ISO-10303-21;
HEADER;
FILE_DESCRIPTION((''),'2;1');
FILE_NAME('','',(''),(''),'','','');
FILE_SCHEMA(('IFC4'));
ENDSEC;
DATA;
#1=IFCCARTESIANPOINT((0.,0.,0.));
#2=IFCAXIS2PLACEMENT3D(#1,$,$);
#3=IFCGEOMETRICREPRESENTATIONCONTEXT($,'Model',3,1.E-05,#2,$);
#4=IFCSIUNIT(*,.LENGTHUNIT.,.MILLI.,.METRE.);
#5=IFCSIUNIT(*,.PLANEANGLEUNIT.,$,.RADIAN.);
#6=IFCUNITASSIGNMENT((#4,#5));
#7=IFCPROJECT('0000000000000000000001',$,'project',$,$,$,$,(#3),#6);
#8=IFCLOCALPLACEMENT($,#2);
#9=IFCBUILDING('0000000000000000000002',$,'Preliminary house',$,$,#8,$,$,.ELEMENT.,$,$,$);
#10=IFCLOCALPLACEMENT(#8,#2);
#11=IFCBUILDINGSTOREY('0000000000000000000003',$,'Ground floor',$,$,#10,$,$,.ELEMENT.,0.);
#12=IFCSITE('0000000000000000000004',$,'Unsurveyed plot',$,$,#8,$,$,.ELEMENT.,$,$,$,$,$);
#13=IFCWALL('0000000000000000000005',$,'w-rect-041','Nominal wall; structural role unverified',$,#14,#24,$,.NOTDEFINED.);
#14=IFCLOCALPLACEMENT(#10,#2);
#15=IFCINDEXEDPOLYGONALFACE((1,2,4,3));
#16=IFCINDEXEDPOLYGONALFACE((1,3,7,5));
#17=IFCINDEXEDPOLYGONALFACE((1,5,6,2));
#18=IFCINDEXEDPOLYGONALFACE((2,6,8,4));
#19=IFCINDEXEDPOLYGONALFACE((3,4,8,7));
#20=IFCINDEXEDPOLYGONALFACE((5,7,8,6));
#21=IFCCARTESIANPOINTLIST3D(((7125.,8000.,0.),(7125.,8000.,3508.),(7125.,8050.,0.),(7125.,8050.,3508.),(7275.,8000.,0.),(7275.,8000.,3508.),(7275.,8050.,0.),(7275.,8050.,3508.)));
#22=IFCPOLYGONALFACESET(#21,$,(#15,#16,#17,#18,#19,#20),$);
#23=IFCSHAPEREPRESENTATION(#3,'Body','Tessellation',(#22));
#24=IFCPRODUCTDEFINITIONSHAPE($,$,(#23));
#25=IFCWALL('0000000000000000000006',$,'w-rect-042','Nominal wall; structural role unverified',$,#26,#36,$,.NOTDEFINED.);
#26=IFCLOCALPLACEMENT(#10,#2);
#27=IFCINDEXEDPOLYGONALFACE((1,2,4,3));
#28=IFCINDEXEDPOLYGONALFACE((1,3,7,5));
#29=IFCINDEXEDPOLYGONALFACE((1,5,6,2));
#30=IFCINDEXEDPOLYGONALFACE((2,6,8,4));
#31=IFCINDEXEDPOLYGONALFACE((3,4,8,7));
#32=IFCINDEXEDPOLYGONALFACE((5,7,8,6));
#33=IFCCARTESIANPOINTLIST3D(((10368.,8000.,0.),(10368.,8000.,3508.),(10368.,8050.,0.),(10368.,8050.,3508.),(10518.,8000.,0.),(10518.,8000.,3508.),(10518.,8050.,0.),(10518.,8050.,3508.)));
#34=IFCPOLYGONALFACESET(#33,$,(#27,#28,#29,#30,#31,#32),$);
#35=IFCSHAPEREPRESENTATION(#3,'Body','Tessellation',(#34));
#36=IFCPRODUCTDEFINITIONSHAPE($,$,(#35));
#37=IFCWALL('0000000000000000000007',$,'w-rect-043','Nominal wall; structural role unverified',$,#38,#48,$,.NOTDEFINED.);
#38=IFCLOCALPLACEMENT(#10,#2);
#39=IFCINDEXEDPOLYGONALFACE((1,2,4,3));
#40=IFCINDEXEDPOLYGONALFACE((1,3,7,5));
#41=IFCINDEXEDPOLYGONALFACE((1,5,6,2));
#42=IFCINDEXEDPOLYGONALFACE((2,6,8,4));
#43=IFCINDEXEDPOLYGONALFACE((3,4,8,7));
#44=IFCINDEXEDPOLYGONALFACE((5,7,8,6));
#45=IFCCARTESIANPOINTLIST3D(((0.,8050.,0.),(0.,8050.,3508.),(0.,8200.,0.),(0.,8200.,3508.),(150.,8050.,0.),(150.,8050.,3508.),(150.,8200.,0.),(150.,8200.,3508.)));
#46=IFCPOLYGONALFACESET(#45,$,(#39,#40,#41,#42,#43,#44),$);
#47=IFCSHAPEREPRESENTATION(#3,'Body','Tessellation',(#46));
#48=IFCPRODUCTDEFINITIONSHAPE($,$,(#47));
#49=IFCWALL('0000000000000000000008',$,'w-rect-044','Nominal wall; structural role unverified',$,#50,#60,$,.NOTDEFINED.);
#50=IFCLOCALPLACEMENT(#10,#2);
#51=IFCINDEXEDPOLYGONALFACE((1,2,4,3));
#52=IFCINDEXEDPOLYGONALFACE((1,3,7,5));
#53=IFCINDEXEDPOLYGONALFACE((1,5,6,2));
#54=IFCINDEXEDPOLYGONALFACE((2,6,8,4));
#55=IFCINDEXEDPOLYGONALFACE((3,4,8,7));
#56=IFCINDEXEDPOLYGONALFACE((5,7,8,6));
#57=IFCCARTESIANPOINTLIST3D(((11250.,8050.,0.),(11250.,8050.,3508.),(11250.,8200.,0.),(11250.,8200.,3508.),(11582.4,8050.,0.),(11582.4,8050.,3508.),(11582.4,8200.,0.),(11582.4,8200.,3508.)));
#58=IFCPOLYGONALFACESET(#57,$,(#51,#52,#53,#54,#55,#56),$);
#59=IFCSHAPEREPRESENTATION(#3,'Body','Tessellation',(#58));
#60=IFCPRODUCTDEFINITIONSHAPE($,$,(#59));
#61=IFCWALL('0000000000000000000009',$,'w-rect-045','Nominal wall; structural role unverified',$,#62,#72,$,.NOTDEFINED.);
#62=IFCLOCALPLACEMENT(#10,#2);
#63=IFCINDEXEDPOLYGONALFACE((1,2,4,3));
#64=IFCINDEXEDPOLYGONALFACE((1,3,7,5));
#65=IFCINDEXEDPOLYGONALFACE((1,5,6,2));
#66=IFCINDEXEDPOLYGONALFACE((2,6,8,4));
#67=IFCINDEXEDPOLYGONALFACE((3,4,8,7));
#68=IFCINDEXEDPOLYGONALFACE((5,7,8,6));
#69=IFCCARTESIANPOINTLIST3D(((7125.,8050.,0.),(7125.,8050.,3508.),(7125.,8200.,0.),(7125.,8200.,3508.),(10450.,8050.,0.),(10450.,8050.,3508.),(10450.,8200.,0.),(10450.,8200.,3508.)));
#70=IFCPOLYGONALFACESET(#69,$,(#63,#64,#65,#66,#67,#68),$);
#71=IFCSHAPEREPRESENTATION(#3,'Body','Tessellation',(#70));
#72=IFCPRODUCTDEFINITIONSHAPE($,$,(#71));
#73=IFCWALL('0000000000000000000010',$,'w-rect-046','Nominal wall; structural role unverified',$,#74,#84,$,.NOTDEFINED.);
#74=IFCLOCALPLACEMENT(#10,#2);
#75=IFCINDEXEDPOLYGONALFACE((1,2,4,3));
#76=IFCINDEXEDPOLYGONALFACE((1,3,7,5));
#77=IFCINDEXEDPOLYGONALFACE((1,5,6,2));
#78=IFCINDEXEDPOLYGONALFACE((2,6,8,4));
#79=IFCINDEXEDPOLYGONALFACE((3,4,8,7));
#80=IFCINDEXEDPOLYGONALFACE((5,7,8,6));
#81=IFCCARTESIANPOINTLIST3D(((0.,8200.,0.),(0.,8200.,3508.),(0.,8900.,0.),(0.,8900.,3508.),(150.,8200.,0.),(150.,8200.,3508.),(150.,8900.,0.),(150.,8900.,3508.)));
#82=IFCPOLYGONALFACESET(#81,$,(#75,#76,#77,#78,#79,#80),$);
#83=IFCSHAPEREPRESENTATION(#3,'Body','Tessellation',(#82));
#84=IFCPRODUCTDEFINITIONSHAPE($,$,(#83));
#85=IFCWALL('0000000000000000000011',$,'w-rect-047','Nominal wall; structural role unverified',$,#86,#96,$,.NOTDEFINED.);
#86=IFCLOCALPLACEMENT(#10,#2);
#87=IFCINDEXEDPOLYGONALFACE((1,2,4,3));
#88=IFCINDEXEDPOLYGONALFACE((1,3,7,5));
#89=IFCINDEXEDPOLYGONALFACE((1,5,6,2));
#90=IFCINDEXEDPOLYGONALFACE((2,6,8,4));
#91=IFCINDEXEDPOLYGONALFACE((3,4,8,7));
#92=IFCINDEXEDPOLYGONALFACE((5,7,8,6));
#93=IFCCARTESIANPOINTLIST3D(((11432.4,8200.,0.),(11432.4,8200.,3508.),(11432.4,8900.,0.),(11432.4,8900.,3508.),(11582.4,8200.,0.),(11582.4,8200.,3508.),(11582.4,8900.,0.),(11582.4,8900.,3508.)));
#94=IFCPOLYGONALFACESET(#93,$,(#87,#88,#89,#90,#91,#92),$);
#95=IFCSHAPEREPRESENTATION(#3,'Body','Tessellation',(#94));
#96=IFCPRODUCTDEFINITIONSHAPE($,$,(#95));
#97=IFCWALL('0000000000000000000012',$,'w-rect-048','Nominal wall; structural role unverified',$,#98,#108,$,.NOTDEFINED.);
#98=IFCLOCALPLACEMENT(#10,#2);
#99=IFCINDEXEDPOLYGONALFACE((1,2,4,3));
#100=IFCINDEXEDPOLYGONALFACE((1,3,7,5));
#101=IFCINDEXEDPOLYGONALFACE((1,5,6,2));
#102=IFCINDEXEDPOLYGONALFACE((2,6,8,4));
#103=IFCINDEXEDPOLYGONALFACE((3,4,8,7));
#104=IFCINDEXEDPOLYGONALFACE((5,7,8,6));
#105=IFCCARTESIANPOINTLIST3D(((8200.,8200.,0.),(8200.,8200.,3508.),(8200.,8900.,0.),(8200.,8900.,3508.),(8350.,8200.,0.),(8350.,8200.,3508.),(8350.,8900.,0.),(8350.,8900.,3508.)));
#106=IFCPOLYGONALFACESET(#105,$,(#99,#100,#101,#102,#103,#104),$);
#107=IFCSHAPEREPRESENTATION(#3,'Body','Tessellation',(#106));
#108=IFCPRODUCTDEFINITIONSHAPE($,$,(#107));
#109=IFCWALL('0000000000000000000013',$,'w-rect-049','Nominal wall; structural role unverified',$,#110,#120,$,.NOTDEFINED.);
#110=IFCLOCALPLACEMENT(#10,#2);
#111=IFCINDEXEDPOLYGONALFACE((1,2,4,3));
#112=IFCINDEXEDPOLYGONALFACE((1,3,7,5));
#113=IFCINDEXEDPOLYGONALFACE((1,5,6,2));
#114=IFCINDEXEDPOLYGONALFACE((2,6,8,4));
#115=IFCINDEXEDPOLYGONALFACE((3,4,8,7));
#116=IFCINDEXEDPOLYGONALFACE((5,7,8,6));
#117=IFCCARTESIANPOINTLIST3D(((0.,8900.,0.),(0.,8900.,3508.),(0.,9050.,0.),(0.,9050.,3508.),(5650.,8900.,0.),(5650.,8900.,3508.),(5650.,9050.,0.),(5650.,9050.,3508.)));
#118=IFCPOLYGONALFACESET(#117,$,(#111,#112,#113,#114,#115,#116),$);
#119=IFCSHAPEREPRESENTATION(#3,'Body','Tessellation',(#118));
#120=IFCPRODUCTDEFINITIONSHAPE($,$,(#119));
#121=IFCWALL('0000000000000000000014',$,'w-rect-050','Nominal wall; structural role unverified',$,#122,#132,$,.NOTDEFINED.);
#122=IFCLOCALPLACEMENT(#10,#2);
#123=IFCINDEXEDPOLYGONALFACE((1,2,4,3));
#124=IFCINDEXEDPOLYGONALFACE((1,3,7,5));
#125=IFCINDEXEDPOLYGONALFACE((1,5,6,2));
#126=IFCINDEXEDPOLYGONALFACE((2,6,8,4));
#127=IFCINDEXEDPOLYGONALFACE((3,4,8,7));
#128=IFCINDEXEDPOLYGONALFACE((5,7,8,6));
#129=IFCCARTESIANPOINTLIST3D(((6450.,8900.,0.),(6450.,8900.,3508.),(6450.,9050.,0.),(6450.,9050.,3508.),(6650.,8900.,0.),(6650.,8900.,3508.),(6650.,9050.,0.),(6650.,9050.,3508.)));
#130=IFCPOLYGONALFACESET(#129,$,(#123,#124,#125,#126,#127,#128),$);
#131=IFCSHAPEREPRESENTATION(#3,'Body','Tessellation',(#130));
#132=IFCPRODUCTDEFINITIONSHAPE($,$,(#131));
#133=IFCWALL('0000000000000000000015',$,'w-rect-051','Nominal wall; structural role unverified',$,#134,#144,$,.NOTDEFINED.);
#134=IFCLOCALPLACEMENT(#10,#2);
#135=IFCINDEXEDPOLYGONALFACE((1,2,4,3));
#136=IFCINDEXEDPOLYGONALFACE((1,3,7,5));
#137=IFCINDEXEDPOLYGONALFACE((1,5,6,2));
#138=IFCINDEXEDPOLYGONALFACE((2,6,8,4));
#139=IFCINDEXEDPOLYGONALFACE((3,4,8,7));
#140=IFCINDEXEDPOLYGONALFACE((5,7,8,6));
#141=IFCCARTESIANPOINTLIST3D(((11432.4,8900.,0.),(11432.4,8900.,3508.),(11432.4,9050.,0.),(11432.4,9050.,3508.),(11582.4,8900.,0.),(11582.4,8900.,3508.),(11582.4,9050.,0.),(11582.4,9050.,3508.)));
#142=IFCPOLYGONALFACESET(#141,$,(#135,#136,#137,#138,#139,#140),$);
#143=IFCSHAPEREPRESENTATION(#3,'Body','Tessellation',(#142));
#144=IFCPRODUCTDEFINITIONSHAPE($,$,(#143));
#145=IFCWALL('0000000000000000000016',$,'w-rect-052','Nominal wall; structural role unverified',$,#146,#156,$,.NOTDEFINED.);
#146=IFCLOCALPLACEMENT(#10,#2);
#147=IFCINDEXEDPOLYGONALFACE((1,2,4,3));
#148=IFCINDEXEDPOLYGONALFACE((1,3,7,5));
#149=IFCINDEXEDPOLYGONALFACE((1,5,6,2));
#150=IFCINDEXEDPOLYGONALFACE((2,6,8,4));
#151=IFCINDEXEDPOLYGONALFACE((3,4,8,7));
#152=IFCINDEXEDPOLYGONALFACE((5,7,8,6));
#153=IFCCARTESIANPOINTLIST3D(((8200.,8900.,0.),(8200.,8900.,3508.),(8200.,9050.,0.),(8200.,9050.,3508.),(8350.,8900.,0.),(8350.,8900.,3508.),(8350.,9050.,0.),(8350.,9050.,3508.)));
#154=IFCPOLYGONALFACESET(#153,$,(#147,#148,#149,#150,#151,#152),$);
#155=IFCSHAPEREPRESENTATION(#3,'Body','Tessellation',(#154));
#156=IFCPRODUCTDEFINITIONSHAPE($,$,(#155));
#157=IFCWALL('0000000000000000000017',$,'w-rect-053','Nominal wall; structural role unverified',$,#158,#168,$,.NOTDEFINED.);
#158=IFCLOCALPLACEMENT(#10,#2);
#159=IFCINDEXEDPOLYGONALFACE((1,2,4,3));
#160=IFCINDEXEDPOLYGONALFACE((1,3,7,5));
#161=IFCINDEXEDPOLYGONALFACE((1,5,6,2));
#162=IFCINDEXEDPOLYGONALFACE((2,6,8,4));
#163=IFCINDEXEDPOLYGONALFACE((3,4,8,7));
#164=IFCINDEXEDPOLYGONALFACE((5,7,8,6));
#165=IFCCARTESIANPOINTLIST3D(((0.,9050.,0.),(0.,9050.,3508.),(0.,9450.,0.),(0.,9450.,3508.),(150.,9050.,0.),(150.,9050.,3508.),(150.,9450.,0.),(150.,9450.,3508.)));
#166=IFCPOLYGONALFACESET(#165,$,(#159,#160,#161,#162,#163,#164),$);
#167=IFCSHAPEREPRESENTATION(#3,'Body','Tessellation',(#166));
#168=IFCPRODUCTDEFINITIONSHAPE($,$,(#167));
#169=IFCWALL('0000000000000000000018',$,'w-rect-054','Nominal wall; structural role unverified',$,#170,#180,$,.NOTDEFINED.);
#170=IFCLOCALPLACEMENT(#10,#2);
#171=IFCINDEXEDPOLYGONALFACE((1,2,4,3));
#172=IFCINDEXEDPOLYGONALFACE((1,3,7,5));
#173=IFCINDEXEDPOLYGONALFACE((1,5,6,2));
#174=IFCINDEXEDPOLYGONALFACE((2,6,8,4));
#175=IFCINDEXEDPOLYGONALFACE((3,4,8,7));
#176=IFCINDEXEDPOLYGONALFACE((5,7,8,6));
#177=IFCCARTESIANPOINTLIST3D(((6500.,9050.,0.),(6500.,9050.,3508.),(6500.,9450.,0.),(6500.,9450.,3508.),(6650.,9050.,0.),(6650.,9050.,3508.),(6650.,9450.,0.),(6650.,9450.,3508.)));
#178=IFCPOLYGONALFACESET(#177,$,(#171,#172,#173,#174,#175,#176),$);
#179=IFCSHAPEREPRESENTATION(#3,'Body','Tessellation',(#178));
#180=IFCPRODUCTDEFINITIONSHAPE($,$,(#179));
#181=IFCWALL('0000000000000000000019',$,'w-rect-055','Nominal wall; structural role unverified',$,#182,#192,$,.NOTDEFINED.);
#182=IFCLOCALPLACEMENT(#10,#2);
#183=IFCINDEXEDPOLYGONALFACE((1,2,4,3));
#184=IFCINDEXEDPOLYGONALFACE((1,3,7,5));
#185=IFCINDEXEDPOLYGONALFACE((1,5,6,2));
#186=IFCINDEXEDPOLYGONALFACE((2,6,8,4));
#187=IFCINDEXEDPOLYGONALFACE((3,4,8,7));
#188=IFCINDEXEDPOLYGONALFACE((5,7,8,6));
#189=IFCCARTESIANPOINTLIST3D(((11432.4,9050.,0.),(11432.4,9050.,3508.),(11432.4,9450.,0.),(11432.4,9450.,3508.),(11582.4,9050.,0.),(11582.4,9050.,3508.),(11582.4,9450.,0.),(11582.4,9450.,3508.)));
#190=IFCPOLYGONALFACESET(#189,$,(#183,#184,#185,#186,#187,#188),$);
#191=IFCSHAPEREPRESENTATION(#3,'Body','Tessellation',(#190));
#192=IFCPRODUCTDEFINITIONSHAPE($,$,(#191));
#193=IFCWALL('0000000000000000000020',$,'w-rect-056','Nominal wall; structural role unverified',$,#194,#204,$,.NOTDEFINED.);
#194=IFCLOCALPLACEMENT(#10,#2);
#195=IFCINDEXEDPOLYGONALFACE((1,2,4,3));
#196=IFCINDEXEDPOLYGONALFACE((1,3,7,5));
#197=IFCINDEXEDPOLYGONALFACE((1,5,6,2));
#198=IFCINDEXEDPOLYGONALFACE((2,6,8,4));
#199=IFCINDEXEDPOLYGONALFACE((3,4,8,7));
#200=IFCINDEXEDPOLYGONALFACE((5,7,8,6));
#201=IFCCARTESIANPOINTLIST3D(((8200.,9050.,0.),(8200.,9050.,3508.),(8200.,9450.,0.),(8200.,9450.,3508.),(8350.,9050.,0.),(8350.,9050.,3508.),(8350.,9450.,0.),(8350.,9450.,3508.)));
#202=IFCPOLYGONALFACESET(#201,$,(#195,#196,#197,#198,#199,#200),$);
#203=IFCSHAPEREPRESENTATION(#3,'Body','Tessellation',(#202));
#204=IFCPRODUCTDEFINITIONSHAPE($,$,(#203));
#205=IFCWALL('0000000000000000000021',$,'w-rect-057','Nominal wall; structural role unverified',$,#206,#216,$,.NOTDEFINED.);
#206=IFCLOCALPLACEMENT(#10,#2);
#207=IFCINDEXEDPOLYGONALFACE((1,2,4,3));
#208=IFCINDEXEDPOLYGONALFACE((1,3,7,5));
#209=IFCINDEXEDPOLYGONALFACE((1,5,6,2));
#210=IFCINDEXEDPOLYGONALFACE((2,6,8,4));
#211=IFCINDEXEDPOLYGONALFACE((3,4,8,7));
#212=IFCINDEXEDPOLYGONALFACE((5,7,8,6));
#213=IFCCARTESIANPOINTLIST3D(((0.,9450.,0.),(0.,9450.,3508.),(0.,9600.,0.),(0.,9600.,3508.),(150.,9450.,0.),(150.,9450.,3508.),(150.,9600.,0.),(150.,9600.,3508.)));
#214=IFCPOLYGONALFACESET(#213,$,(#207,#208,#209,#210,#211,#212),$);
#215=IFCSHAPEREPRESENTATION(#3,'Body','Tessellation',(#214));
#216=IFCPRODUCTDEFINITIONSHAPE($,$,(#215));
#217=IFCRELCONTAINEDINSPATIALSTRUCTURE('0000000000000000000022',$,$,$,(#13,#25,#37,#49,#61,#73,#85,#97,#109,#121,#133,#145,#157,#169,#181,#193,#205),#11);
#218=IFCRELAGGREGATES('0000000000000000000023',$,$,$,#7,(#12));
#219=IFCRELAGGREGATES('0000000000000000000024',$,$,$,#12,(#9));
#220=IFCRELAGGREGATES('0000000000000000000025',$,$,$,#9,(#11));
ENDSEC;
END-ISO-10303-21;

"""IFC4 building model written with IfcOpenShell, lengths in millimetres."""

from ifc_helpers import new_model, si_unit, origin, place, context, project, spatial, polyline, outline, extrude, element, save


model = new_model("IFC4")

# Units and contexts
model_context = context("Model", 3, precision=1e-05, world=origin())
ifc_project = project(units=[si_unit("LENGTHUNIT", "METRE", prefix="MILLI"), si_unit("PLANEANGLEUNIT", "RADIAN")], contexts=[model_context])

# Site, building, storey
placement_1 = place(None, origin())
site = spatial("IfcSite", under=ifc_project, at=placement_1, Name="Unsurveyed plot", CompositionType="ELEMENT")
building = spatial("IfcBuilding", under=site, at=placement_1, Name="Preliminary house", CompositionType="ELEMENT")
placement_2 = place(placement_1, origin())
storey = spatial("IfcBuildingStorey", under=building, at=placement_2, Name="Ground floor", CompositionType="ELEMENT", Elevation=0.0)

# Walls
element("IfcWall", 1, at=placement_2, inside=storey, Name="w-rect-041", Description="Nominal wall; structural role unverified", PredefinedType="NOTDEFINED", context=model_context, shape_type="SweptSolid", body=[
    extrude(outline(polyline([(7125.0, 8000.0), (7275.0, 8000.0), (7275.0, 8050.0), (7125.0, 8050.0), (7125.0, 8000.0)])), origin(), (0.0, 0.0, 1.0), 3508.0),
])
element("IfcWall", 2, at=placement_2, inside=storey, Name="w-rect-042", Description="Nominal wall; structural role unverified", PredefinedType="NOTDEFINED", context=model_context, shape_type="SweptSolid", body=[
    extrude(outline(polyline([(10368.0, 8000.0), (10518.0, 8000.0), (10518.0, 8050.0), (10368.0, 8050.0), (10368.0, 8000.0)])), origin(), (0.0, 0.0, 1.0), 3508.0),
])
element("IfcWall", 3, at=placement_2, inside=storey, Name="w-rect-043", Description="Nominal wall; structural role unverified", PredefinedType="NOTDEFINED", context=model_context, shape_type="SweptSolid", body=[
    extrude(outline(polyline([(0.0, 8050.0), (150.0, 8050.0), (150.0, 8200.0), (0.0, 8200.0), (0.0, 8050.0)])), origin(), (0.0, 0.0, 1.0), 3508.0),
])
element("IfcWall", 4, at=placement_2, inside=storey, Name="w-rect-044", Description="Nominal wall; structural role unverified", PredefinedType="NOTDEFINED", context=model_context, shape_type="SweptSolid", body=[
    extrude(outline(polyline([(11250.0, 8050.0), (11582.4, 8050.0), (11582.4, 8200.0), (11250.0, 8200.0), (11250.0, 8050.0)])), origin(), (0.0, 0.0, 1.0), 3508.0),
])
element("IfcWall", 5, at=placement_2, inside=storey, Name="w-rect-045", Description="Nominal wall; structural role unverified", PredefinedType="NOTDEFINED", context=model_context, shape_type="SweptSolid", body=[
    extrude(outline(polyline([(7125.0, 8050.0), (10450.0, 8050.0), (10450.0, 8200.0), (7125.0, 8200.0), (7125.0, 8050.0)])), origin(), (0.0, 0.0, 1.0), 3508.0),
])
element("IfcWall", 6, at=placement_2, inside=storey, Name="w-rect-046", Description="Nominal wall; structural role unverified", PredefinedType="NOTDEFINED", context=model_context, shape_type="SweptSolid", body=[
    extrude(outline(polyline([(0.0, 8200.0), (150.0, 8200.0), (150.0, 8900.0), (0.0, 8900.0), (0.0, 8200.0)])), origin(), (0.0, 0.0, 1.0), 3508.0),
])
element("IfcWall", 7, at=placement_2, inside=storey, Name="w-rect-047", Description="Nominal wall; structural role unverified", PredefinedType="NOTDEFINED", context=model_context, shape_type="SweptSolid", body=[
    extrude(outline(polyline([(11432.4, 8200.0), (11582.4, 8200.0), (11582.4, 8900.0), (11432.4, 8900.0), (11432.4, 8200.0)])), origin(), (0.0, 0.0, 1.0), 3508.0),
])
element("IfcWall", 8, at=placement_2, inside=storey, Name="w-rect-048", Description="Nominal wall; structural role unverified", PredefinedType="NOTDEFINED", context=model_context, shape_type="SweptSolid", body=[
    extrude(outline(polyline([(8200.0, 8200.0), (8350.0, 8200.0), (8350.0, 8900.0), (8200.0, 8900.0), (8200.0, 8200.0)])), origin(), (0.0, 0.0, 1.0), 3508.0),
])
element("IfcWall", 9, at=placement_2, inside=storey, Name="w-rect-049", Description="Nominal wall; structural role unverified", PredefinedType="NOTDEFINED", context=model_context, shape_type="SweptSolid", body=[
    extrude(outline(polyline([(0.0, 8900.0), (5650.0, 8900.0), (5650.0, 9050.0), (0.0, 9050.0), (0.0, 8900.0)])), origin(), (0.0, 0.0, 1.0), 3508.0),
])
element("IfcWall", 10, at=placement_2, inside=storey, Name="w-rect-050", Description="Nominal wall; structural role unverified", PredefinedType="NOTDEFINED", context=model_context, shape_type="SweptSolid", body=[
    extrude(outline(polyline([(6450.0, 8900.0), (6650.0, 8900.0), (6650.0, 9050.0), (6450.0, 9050.0), (6450.0, 8900.0)])), origin(), (0.0, 0.0, 1.0), 3508.0),
])
element("IfcWall", 11, at=placement_2, inside=storey, Name="w-rect-051", Description="Nominal wall; structural role unverified", PredefinedType="NOTDEFINED", context=model_context, shape_type="SweptSolid", body=[
    extrude(outline(polyline([(11432.4, 8900.0), (11582.4, 8900.0), (11582.4, 9050.0), (11432.4, 9050.0), (11432.4, 8900.0)])), origin(), (0.0, 0.0, 1.0), 3508.0),
])
element("IfcWall", 12, at=placement_2, inside=storey, Name="w-rect-052", Description="Nominal wall; structural role unverified", PredefinedType="NOTDEFINED", context=model_context, shape_type="SweptSolid", body=[
    extrude(outline(polyline([(8200.0, 8900.0), (8350.0, 8900.0), (8350.0, 9050.0), (8200.0, 9050.0), (8200.0, 8900.0)])), origin(), (0.0, 0.0, 1.0), 3508.0),
])
element("IfcWall", 13, at=placement_2, inside=storey, Name="w-rect-053", Description="Nominal wall; structural role unverified", PredefinedType="NOTDEFINED", context=model_context, shape_type="SweptSolid", body=[
    extrude(outline(polyline([(0.0, 9050.0), (150.0, 9050.0), (150.0, 9450.0), (0.0, 9450.0), (0.0, 9050.0)])), origin(), (0.0, 0.0, 1.0), 3508.0),
])
element("IfcWall", 14, at=placement_2, inside=storey, Name="w-rect-054", Description="Nominal wall; structural role unverified", PredefinedType="NOTDEFINED", context=model_context, shape_type="SweptSolid", body=[
    extrude(outline(polyline([(6500.0, 9050.0), (6650.0, 9050.0), (6650.0, 9450.0), (6500.0, 9450.0), (6500.0, 9050.0)])), origin(), (0.0, 0.0, 1.0), 3508.0),
])
element("IfcWall", 15, at=placement_2, inside=storey, Name="w-rect-055", Description="Nominal wall; structural role unverified", PredefinedType="NOTDEFINED", context=model_context, shape_type="SweptSolid", body=[
    extrude(outline(polyline([(11432.4, 9050.0), (11582.4, 9050.0), (11582.4, 9450.0), (11432.4, 9450.0), (11432.4, 9050.0)])), origin(), (0.0, 0.0, 1.0), 3508.0),
])
element("IfcWall", 16, at=placement_2, inside=storey, Name="w-rect-056", Description="Nominal wall; structural role unverified", PredefinedType="NOTDEFINED", context=model_context, shape_type="SweptSolid", body=[
    extrude(outline(polyline([(8200.0, 9050.0), (8350.0, 9050.0), (8350.0, 9450.0), (8200.0, 9450.0), (8200.0, 9050.0)])), origin(), (0.0, 0.0, 1.0), 3508.0),
])
element("IfcWall", 17, at=placement_2, inside=storey, Name="w-rect-057", Description="Nominal wall; structural role unverified", PredefinedType="NOTDEFINED", context=model_context, shape_type="SweptSolid", body=[
    extrude(outline(polyline([(0.0, 9450.0), (150.0, 9450.0), (150.0, 9600.0), (0.0, 9600.0), (0.0, 9450.0)])), origin(), (0.0, 0.0, 1.0), 3508.0),
])

save(model, "model.ifc")
